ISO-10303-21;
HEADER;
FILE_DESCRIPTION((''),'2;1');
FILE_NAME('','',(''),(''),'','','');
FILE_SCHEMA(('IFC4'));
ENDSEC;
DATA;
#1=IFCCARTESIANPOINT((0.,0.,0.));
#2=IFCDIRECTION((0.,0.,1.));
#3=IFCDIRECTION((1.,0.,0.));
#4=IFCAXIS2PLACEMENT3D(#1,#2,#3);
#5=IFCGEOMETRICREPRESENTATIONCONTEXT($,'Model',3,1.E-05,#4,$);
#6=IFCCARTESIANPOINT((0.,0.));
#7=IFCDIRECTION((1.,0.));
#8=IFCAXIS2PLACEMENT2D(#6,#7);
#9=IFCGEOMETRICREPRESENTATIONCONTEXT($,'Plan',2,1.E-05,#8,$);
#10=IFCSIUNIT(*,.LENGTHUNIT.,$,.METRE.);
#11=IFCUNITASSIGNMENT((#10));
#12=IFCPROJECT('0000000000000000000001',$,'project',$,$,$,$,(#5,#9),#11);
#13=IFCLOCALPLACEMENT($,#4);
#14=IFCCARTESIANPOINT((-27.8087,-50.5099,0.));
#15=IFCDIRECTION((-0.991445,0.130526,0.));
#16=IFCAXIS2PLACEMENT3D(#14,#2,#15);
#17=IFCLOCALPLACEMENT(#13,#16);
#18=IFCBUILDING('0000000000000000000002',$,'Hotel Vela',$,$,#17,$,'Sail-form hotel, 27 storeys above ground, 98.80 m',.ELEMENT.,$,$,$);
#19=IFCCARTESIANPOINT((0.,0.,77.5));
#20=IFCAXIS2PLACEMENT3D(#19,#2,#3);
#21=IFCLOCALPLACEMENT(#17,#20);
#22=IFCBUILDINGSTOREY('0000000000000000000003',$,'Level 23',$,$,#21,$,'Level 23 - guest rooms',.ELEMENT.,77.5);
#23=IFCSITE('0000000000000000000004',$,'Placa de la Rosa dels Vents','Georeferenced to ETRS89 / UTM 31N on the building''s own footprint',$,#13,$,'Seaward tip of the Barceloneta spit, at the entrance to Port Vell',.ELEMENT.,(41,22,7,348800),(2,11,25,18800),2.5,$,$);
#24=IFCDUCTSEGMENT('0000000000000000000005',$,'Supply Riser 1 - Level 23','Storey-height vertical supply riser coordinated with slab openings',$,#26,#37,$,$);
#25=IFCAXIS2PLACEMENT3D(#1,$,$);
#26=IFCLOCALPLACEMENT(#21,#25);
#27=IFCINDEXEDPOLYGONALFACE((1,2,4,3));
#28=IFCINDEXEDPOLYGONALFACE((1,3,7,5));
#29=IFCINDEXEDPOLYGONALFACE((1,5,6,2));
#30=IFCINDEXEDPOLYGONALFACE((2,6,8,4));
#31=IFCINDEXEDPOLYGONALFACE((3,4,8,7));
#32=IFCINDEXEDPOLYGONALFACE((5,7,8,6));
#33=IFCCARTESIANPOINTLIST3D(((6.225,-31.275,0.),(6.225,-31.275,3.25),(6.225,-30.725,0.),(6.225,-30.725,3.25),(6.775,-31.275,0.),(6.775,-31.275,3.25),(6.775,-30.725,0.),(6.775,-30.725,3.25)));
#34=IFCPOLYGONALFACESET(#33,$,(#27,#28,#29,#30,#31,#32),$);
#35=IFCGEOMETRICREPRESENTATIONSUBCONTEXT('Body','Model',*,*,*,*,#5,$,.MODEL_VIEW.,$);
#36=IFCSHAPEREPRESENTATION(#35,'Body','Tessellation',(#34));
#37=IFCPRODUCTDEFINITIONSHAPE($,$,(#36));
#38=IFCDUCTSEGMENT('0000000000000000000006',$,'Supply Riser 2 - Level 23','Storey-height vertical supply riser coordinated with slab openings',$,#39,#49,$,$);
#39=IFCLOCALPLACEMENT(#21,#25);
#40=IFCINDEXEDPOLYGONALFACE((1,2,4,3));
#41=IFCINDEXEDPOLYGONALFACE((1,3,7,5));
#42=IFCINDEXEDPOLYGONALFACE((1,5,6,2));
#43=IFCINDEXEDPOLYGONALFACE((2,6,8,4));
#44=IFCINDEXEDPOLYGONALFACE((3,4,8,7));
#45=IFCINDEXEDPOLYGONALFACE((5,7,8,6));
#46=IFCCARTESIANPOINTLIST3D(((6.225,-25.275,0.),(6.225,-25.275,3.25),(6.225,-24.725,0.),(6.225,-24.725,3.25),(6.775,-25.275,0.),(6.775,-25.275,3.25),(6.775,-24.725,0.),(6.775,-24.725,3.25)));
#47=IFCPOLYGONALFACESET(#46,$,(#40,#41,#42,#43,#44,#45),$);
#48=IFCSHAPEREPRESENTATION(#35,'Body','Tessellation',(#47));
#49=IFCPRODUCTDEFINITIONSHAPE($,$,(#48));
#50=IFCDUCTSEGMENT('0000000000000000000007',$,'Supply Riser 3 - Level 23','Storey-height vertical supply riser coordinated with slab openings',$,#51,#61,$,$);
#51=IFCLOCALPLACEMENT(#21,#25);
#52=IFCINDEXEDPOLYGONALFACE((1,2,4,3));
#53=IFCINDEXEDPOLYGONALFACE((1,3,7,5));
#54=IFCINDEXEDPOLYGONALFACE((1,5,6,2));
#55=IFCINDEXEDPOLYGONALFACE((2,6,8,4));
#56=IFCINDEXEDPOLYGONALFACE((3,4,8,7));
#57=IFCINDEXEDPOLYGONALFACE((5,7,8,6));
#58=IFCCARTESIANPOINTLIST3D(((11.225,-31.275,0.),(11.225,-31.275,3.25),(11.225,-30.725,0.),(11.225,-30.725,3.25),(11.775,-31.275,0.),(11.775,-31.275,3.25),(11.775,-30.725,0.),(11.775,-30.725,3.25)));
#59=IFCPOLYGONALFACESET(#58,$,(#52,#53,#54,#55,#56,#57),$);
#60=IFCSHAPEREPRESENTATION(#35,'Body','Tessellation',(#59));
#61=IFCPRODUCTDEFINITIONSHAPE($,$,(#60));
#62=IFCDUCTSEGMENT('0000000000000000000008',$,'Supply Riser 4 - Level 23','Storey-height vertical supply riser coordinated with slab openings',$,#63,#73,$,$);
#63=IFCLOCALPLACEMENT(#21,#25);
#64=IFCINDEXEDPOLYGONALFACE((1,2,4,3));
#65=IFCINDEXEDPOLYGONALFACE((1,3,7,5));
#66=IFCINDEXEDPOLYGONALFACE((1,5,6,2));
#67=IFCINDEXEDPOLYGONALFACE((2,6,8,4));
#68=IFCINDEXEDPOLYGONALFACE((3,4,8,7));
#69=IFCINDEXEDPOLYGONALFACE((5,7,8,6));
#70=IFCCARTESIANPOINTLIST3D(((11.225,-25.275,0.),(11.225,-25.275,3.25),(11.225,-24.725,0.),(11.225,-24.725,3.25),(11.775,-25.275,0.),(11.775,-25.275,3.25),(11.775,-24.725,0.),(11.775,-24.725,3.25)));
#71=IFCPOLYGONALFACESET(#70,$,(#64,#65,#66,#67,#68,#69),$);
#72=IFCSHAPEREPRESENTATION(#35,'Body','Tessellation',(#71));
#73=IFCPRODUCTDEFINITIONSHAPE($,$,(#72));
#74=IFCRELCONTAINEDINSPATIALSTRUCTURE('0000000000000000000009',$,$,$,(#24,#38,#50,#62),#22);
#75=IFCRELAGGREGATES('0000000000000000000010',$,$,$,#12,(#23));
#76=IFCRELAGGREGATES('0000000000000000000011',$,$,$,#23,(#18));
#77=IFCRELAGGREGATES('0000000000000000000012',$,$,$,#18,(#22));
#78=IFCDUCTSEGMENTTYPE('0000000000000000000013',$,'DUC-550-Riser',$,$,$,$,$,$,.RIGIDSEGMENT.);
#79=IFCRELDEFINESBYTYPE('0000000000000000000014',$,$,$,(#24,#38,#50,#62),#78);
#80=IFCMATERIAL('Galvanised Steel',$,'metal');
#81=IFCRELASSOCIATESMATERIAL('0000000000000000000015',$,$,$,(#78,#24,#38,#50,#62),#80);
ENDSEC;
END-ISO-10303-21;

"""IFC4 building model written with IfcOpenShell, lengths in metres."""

from ifc_helpers import new_model, si_unit, frame, origin_with_axes, origin_2d_with_axis, place, context, subcontext, project, spatial, line, indexed_curve, outline, extrude, material, type_object, element, save


model = new_model("IFC4")

# Units and contexts
model_context = context("Model", 3, precision=1e-05, world=origin_with_axes())
plan_context = context("Plan", 2, precision=1e-05, world=origin_2d_with_axis())
body_context = subcontext(model_context, "Body", "Model", "MODEL_VIEW")
ifc_project = project(units=[si_unit("LENGTHUNIT", "METRE")], contexts=[model_context, plan_context])

# Site, building, storey
site_placement = place(None, origin_with_axes())
site = spatial("IfcSite", under=ifc_project, at=site_placement, Name="Placa de la Rosa dels Vents", Description="Georeferenced to ETRS89 / UTM 31N on the building's own footprint", LongName="Seaward tip of the Barceloneta spit, at the entrance to Port Vell", CompositionType="ELEMENT", RefLatitude=(41, 22, 7, 348800), RefLongitude=(2, 11, 25, 18800), RefElevation=2.5)
building_placement = place(site_placement, frame((-27.8087, -50.5099, 0.0), z_axis=(0.0, 0.0, 1.0), x_axis=(-0.991445, 0.130526, 0.0)))
building = spatial("IfcBuilding", under=site, at=building_placement, Name="Hotel Vela", LongName="Sail-form hotel, 27 storeys above ground, 98.80 m", CompositionType="ELEMENT")
storey_placement = place(building_placement, frame((0.0, 0.0, 77.5), z_axis=(0.0, 0.0, 1.0), x_axis=(1.0, 0.0, 0.0)))
storey = spatial("IfcBuildingStorey", under=building, at=storey_placement, Name="Level 23", LongName="Level 23 - guest rooms", CompositionType="ELEMENT", Elevation=77.5)

# Duct segments
ifc_material = material(Name="Galvanised Steel", Category="metal")
duct_segment_type = type_object("IfcDuctSegmentType", Name="DUC-550-Riser", PredefinedType="RIGIDSEGMENT", material=ifc_material)
for number, where, z_axis, x_axis, name in (
    (1, (6.225, -31.275, 0.0), (0.0, 0.0, 1.0), (1.0, 0.0, 0.0), "Supply Riser 1 - Level 23"),
    (2, (6.225, -25.275, 0.0), (0.0, 0.0, 1.0), (1.0, 0.0, 0.0), "Supply Riser 2 - Level 23"),
    (3, (11.225, -31.275, 0.0), (0.0, 0.0, 1.0), (1.0, 0.0, 0.0), "Supply Riser 3 - Level 23"),
    (4, (11.225, -25.275, 0.0), (0.0, 0.0, 1.0), (1.0, 0.0, 0.0), "Supply Riser 4 - Level 23"),
):
    element("IfcDuctSegment", number, at=place(storey_placement, frame(where, z_axis=z_axis, x_axis=x_axis)), inside=storey, type_object=duct_segment_type, material=ifc_material, Name=name, Description="Storey-height vertical supply riser coordinated with slab openings", context=body_context, shape_type="SweptSolid", body=[
        extrude(outline(indexed_curve([(0.0, 0.0), (0.55, 0.0), (0.55, 0.55), (0.0, 0.55)], segments=[line(1, 2, 3, 4, 1)])), origin_with_axes(), (0.0, 0.0, 1.0), 3.25),
    ])

save(model, "model.ifc")
